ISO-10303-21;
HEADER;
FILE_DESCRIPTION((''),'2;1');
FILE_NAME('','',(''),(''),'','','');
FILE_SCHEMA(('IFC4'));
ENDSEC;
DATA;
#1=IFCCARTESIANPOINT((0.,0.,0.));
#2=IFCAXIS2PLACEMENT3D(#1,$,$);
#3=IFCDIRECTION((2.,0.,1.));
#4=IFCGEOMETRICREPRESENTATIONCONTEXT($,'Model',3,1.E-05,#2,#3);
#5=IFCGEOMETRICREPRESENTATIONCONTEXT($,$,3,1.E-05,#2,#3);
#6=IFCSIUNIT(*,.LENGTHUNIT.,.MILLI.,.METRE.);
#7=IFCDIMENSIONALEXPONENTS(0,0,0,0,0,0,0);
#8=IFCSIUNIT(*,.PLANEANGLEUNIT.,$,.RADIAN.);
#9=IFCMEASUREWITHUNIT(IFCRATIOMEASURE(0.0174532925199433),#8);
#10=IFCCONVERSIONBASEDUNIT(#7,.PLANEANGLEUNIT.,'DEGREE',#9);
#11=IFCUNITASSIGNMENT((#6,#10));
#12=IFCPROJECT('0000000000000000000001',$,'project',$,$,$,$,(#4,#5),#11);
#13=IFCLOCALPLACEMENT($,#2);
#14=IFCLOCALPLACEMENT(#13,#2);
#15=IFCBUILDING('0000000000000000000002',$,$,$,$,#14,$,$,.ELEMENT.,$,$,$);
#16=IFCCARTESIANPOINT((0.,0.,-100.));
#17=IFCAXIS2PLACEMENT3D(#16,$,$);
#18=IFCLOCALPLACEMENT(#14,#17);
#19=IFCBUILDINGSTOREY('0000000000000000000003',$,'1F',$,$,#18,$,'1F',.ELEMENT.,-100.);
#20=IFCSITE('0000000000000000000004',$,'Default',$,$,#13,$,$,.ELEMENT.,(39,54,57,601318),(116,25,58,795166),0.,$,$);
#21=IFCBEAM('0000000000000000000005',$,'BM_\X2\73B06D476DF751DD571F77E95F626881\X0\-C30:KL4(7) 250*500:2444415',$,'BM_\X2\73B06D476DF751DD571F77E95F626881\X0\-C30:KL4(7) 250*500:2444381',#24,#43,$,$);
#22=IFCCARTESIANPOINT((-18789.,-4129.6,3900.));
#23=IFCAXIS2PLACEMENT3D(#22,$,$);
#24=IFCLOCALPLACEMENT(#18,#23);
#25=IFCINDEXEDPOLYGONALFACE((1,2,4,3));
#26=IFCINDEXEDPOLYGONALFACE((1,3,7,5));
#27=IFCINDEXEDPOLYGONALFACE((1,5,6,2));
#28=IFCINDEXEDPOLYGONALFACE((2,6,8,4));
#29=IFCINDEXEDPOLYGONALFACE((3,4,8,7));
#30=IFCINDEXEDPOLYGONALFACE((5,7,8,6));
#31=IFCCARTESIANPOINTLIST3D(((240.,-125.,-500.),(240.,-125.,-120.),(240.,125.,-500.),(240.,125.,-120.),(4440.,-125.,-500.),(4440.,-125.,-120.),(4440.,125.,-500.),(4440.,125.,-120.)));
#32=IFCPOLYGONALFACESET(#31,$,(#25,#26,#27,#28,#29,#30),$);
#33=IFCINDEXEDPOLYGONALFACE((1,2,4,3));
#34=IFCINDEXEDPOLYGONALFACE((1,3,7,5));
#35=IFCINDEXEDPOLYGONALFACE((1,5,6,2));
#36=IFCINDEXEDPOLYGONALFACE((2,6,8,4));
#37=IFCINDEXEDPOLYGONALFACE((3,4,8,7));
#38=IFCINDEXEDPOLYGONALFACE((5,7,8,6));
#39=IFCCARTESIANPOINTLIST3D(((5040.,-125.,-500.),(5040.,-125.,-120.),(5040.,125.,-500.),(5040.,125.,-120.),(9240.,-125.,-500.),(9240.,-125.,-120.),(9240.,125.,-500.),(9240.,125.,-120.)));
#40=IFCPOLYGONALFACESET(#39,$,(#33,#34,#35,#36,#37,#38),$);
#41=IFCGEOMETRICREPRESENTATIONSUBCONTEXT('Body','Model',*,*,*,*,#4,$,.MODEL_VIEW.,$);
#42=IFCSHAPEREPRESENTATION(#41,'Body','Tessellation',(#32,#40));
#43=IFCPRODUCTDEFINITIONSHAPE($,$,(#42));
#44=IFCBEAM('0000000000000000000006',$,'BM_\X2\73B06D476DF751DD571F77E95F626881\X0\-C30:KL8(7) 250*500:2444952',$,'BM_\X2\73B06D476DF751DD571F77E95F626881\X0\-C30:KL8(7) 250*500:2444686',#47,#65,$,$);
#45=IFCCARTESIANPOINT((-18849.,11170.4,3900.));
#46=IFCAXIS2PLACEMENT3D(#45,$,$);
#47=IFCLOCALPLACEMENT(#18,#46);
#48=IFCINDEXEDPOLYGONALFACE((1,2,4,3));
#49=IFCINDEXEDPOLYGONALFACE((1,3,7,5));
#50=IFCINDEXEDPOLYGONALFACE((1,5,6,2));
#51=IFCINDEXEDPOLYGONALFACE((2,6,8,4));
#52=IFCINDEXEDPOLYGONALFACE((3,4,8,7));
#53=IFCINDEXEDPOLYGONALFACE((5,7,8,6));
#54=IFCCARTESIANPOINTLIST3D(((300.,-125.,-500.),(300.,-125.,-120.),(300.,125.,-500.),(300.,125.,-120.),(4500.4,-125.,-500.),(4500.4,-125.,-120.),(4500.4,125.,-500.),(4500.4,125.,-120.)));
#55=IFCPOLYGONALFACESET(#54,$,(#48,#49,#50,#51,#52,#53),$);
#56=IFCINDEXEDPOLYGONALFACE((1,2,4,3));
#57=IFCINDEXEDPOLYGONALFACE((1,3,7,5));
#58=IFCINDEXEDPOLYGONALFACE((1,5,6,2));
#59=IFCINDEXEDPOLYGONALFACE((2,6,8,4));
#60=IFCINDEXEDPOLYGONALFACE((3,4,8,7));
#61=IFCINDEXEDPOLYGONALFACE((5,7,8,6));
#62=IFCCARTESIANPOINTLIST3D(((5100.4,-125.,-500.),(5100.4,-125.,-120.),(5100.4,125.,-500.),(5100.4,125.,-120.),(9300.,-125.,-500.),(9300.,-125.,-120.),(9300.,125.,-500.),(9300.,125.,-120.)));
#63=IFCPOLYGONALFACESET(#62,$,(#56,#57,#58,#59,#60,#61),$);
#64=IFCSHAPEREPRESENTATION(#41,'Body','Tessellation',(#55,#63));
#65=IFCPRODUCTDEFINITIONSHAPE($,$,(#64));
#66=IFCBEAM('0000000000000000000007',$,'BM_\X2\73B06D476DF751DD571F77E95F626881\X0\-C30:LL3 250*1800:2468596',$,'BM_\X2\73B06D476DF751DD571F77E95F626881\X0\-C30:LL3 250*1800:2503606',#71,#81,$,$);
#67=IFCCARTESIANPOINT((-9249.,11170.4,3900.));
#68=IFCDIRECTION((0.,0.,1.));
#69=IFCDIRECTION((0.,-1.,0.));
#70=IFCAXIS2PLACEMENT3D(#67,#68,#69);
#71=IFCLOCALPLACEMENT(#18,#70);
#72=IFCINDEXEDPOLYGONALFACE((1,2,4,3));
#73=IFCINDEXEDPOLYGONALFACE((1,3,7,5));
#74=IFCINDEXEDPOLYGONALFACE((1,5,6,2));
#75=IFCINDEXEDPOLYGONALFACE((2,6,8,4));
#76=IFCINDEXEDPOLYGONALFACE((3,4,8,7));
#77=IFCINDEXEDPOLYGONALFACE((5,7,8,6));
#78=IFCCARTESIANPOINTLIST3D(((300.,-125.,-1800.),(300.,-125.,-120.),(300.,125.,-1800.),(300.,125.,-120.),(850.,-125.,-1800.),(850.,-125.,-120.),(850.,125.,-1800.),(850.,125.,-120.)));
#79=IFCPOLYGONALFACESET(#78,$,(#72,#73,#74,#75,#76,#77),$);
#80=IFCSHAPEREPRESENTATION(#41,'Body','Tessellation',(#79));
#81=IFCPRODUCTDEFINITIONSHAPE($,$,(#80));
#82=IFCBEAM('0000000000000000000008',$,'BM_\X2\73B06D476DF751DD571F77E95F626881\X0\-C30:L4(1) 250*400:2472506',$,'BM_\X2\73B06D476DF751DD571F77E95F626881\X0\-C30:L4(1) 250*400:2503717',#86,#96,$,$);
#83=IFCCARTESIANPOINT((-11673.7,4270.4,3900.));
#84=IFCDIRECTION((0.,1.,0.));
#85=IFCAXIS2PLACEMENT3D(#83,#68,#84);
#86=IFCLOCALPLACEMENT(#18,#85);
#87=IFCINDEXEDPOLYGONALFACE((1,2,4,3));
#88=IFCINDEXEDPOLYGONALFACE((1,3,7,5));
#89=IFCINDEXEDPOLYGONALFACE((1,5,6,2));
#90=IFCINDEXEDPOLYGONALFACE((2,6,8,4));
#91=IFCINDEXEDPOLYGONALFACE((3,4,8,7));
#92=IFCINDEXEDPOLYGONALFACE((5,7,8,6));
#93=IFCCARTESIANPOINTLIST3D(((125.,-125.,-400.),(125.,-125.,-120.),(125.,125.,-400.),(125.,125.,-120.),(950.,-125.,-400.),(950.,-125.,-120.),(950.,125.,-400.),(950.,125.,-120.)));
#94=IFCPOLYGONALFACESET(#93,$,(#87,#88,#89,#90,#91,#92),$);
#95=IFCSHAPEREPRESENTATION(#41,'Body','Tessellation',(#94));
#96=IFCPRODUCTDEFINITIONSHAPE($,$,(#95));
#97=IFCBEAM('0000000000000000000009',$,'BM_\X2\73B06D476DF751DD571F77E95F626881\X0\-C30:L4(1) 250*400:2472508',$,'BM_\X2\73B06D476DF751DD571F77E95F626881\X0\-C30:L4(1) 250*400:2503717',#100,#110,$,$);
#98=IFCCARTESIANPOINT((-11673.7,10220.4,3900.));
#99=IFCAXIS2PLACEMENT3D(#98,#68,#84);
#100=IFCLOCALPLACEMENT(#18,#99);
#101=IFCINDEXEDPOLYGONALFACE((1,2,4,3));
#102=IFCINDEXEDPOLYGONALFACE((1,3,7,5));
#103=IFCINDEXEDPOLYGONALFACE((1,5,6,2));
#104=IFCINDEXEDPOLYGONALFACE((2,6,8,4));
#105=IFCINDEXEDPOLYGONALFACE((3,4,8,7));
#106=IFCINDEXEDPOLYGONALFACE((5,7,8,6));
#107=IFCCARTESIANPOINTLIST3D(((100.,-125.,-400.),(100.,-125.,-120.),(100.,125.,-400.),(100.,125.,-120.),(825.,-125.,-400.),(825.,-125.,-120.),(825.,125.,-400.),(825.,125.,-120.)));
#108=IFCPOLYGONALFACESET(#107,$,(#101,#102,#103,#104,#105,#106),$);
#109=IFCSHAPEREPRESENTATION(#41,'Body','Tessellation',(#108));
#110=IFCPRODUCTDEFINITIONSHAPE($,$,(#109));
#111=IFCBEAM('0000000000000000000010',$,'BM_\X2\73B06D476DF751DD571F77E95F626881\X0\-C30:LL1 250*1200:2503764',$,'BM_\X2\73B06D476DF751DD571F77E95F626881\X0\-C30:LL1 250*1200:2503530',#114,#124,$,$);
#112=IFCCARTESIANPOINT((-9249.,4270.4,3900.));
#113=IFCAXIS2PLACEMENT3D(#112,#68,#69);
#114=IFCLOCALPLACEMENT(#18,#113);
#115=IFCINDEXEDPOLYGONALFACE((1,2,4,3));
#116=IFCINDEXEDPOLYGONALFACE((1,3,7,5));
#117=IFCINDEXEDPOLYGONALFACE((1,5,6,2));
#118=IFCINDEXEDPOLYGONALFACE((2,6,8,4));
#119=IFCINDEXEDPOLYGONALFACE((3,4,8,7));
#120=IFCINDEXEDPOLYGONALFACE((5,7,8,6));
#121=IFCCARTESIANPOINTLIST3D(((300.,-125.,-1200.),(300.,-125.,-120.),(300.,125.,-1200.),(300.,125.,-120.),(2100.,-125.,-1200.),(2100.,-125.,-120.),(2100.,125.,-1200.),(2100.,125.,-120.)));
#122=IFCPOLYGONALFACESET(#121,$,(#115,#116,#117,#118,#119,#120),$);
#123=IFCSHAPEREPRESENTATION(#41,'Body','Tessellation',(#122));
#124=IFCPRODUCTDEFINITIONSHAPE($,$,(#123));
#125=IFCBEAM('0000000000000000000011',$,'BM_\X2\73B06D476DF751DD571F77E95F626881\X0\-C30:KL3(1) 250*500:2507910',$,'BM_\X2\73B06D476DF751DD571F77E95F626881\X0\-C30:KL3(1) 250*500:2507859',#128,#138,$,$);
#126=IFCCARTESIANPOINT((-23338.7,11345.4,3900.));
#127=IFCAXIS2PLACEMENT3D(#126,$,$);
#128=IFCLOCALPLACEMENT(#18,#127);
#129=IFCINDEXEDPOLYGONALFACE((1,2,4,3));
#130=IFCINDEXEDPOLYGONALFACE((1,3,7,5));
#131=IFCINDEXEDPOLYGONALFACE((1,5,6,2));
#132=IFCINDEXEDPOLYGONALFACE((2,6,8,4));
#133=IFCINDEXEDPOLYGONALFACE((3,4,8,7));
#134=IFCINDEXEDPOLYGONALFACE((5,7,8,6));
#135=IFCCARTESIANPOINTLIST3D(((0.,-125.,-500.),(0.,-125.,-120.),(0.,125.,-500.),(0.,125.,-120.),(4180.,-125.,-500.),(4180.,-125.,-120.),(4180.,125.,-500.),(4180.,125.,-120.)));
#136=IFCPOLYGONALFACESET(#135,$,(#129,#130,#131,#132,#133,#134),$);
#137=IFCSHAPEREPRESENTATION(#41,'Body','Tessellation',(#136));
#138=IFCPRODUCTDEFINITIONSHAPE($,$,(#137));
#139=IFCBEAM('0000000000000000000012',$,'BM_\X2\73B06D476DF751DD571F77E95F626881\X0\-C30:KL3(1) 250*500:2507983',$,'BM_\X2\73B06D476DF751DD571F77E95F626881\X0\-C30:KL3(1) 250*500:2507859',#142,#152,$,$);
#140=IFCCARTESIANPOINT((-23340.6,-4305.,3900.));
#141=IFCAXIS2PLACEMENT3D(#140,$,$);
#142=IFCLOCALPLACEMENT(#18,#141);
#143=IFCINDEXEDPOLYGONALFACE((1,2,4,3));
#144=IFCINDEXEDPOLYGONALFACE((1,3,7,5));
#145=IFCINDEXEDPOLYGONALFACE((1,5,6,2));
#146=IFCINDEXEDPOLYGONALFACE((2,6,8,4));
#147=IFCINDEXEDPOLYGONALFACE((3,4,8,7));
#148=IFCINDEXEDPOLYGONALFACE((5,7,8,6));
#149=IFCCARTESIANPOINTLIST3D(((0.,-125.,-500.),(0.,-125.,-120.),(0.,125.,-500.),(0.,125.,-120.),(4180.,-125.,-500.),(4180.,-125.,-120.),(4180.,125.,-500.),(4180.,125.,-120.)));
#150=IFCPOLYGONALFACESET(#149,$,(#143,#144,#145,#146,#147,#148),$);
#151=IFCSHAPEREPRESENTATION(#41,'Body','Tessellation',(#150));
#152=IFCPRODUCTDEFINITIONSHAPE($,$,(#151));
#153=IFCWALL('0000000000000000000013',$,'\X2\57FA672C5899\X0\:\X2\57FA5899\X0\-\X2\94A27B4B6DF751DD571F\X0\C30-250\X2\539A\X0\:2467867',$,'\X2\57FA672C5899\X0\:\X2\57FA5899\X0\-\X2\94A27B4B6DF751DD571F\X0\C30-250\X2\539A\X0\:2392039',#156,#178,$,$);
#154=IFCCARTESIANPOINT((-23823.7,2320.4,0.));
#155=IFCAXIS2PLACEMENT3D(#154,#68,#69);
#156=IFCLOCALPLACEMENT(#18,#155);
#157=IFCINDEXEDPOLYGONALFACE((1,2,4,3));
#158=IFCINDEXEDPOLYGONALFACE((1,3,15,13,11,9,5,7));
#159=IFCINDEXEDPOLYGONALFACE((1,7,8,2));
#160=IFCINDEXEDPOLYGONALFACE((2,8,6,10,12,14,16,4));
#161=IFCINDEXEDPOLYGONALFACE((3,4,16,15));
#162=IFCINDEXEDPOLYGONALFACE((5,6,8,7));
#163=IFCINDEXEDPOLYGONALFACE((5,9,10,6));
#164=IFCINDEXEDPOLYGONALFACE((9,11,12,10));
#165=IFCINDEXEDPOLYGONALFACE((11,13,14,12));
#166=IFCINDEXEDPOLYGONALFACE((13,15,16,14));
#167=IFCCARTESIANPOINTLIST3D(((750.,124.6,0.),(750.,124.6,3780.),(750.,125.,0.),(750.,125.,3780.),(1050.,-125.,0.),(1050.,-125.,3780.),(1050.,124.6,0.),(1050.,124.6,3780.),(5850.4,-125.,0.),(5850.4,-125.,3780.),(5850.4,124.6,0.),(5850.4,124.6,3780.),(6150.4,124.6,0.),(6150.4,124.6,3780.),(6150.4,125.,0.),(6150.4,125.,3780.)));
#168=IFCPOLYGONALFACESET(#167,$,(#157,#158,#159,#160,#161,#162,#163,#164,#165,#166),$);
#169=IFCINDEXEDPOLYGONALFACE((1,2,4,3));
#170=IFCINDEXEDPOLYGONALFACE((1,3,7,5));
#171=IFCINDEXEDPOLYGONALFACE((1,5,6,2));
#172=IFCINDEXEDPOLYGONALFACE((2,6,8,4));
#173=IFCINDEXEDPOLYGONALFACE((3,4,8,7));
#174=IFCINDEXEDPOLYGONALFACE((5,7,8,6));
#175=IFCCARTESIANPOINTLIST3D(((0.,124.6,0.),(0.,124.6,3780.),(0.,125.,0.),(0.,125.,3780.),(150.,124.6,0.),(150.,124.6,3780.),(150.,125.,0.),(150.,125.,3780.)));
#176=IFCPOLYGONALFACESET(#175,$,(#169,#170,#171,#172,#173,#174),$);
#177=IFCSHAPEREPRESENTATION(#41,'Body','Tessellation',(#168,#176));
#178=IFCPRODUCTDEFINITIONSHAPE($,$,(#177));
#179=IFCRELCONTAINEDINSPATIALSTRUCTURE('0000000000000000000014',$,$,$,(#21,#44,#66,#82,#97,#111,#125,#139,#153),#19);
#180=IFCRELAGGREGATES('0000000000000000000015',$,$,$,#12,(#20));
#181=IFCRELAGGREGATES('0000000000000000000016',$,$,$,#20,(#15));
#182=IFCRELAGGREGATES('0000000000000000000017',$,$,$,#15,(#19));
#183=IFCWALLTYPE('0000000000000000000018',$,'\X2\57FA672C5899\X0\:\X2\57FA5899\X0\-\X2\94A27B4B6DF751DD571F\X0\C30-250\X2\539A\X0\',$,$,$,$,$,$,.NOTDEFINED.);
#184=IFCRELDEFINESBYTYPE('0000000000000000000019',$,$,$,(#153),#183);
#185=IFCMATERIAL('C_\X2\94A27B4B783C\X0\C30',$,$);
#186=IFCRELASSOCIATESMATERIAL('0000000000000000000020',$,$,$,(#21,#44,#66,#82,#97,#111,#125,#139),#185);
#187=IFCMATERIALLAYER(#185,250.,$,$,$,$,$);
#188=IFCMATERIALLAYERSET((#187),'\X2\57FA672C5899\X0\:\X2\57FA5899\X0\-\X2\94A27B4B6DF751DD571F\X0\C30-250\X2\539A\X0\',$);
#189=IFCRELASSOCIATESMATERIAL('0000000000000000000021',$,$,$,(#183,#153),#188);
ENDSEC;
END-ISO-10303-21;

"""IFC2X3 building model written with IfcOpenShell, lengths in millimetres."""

from ifc_helpers import new_model, entity, si_unit, converted_unit, direction, frame, frame_2d, origin, origin_2d_with_axis, place, context, subcontext, project, spatial, polyline, rectangle, outline, extrude, material, layer, layer_set, type_object, element, save


model = new_model("IFC2X3")

# Units and contexts
model_context = context("Model", 3, precision=1e-05, world=origin(), true_north=direction((2.0, 0.0, 1.0)))
context_of_model = context(None, 3, precision=1e-05, world=origin(), true_north=direction((2.0, 0.0, 1.0)))
body_context = subcontext(model_context, "Body", "Model", "MODEL_VIEW")
ifc_project = project(units=[si_unit("LENGTHUNIT", "METRE", prefix="MILLI"), converted_unit("PLANEANGLEUNIT", "DEGREE", entity("IfcRatioMeasure", 0.0174532925199433), si_unit("PLANEANGLEUNIT", "RADIAN"), dimensions=[0, 0, 0, 0, 0, 0, 0])], contexts=[model_context, context_of_model])

# Site, building, storey
site_placement = place(None, origin())
site = spatial("IfcSite", under=ifc_project, at=site_placement, Name="Default", CompositionType="ELEMENT", RefLatitude=(39, 54, 57, 601318), RefLongitude=(116, 25, 58, 795166), RefElevation=0.0)
building_placement = place(site_placement, origin())
building = spatial("IfcBuilding", under=site, at=building_placement, CompositionType="ELEMENT")
storey_placement = place(building_placement, frame((0.0, 0.0, -100.0)))
storey = spatial("IfcBuildingStorey", under=building, at=storey_placement, Name="1F", LongName="1F", CompositionType="ELEMENT", Elevation=-100.0)

# Beams
ifc_material = material(Name="C_钢筋砼C30")
beam_1_placement = place(storey_placement, frame((-18789.0, -4129.6, 3900.0)))
element("IfcBeam", 1, at=beam_1_placement, inside=storey, material=ifc_material, Name="BM_现浇混凝土矩形梁-C30:KL4(7) 250*500:2444415", ObjectType="BM_现浇混凝土矩形梁-C30:KL4(7) 250*500:2444381", context=body_context, shape_type="SweptSolid", body=[
    extrude(rectangle(XDim=380.0, YDim=250.0, at=origin_2d_with_axis()), frame((240.0, 0.0, -310.0), z_axis=(1.0, 0.0, 0.0), x_axis=(0.0, 0.0, 1.0)), (0.0, 0.0, 1.0), 4200.0),
    extrude(rectangle(XDim=380.0, YDim=250.0, at=frame_2d((0.0, 0.0), x_axis=(1.0, 0.0))), frame((5040.0, 0.0, -310.0), z_axis=(1.0, 0.0, 0.0), x_axis=(0.0, 0.0, 1.0)), (0.0, 0.0, 1.0), 4200.0),
])
beam_2_placement = place(storey_placement, frame((-18849.0, 11170.4, 3900.0)))
element("IfcBeam", 2, at=beam_2_placement, inside=storey, material=ifc_material, Name="BM_现浇混凝土矩形梁-C30:KL8(7) 250*500:2444952", ObjectType="BM_现浇混凝土矩形梁-C30:KL8(7) 250*500:2444686", context=body_context, shape_type="SweptSolid", body=[
    extrude(rectangle(XDim=380.0, YDim=250.0, at=origin_2d_with_axis()), frame((300.0, 0.0, -310.0), z_axis=(1.0, 0.0, 0.0), x_axis=(0.0, 0.0, 1.0)), (0.0, 0.0, 1.0), 4200.4),
    extrude(rectangle(XDim=380.0, YDim=250.0, at=origin_2d_with_axis()), frame((5100.4, 0.0, -310.0), z_axis=(1.0, 0.0, 0.0), x_axis=(0.0, 0.0, 1.0)), (0.0, 0.0, 1.0), 4199.6),
])
beam_3_placement = place(storey_placement, frame((-9249.0, 11170.4, 3900.0), z_axis=(0.0, 0.0, 1.0), x_axis=(0.0, -1.0, 0.0)))
element("IfcBeam", 3, at=beam_3_placement, inside=storey, material=ifc_material, Name="BM_现浇混凝土矩形梁-C30:LL3 250*1800:2468596", ObjectType="BM_现浇混凝土矩形梁-C30:LL3 250*1800:2503606", context=body_context, shape_type="SweptSolid", body=[
    extrude(rectangle(XDim=1680.0, YDim=250.0, at=frame_2d((0.0, 0.0), x_axis=(1.0, 0.0))), frame((300.0, 0.0, -960.0), z_axis=(1.0, 0.0, 0.0), x_axis=(0.0, 0.0, -1.0)), (0.0, 0.0, 1.0), 550.0),
])
beam_4_placement = place(storey_placement, frame((-11673.7, 4270.4, 3900.0), z_axis=(0.0, 0.0, 1.0), x_axis=(0.0, 1.0, 0.0)))
element("IfcBeam", 4, at=beam_4_placement, inside=storey, material=ifc_material, Name="BM_现浇混凝土矩形梁-C30:L4(1) 250*400:2472506", ObjectType="BM_现浇混凝土矩形梁-C30:L4(1) 250*400:2503717", context=body_context, shape_type="SweptSolid", body=[
    extrude(rectangle(XDim=280.0, YDim=250.0, at=frame_2d((0.0, 0.0), x_axis=(1.0, 0.0))), frame((125.0, 0.0, -260.0), z_axis=(1.0, 0.0, 0.0), x_axis=(0.0, 0.0, -1.0)), (0.0, 0.0, 1.0), 825.0),
])
beam_5_placement = place(storey_placement, frame((-11673.7, 10220.4, 3900.0), z_axis=(0.0, 0.0, 1.0), x_axis=(0.0, 1.0, 0.0)))
element("IfcBeam", 5, at=beam_5_placement, inside=storey, material=ifc_material, Name="BM_现浇混凝土矩形梁-C30:L4(1) 250*400:2472508", ObjectType="BM_现浇混凝土矩形梁-C30:L4(1) 250*400:2503717", context=body_context, shape_type="SweptSolid", body=[
    extrude(rectangle(XDim=280.0, YDim=250.0, at=origin_2d_with_axis()), frame((100.0, 0.0, -260.0), z_axis=(1.0, 0.0, 0.0), x_axis=(0.0, 0.0, -1.0)), (0.0, 0.0, 1.0), 725.0),
])
beam_6_placement = place(storey_placement, frame((-9249.0, 4270.4, 3900.0), z_axis=(0.0, 0.0, 1.0), x_axis=(0.0, -1.0, 0.0)))
element("IfcBeam", 6, at=beam_6_placement, inside=storey, material=ifc_material, Name="BM_现浇混凝土矩形梁-C30:LL1 250*1200:2503764", ObjectType="BM_现浇混凝土矩形梁-C30:LL1 250*1200:2503530", context=body_context, shape_type="SweptSolid", body=[
    extrude(rectangle(XDim=1080.0, YDim=250.0, at=frame_2d((0.0, 0.0), x_axis=(1.0, 0.0))), frame((300.0, 0.0, -660.0), z_axis=(1.0, 0.0, 0.0), x_axis=(0.0, 0.0, -1.0)), (0.0, 0.0, 1.0), 1800.0),
])
for number, where, name in (
    (7, (-23338.7, 11345.4, 3900.0), "BM_现浇混凝土矩形梁-C30:KL3(1) 250*500:2507910"),
    (8, (-23340.6, -4305.0, 3900.0), "BM_现浇混凝土矩形梁-C30:KL3(1) 250*500:2507983"),
):
    element("IfcBeam", number, at=place(storey_placement, frame(where)), inside=storey, material=ifc_material, Name=name, ObjectType="BM_现浇混凝土矩形梁-C30:KL3(1) 250*500:2507859", context=body_context, shape_type="SweptSolid", body=[
        extrude(rectangle(XDim=380.0, YDim=250.0, at=frame_2d((0.0, 0.0), x_axis=(1.0, 0.0))), frame((0.0, 0.0, -310.0), z_axis=(1.0, 0.0, 0.0), x_axis=(0.0, 0.0, -1.0)), (0.0, 0.0, 1.0), 4180.0),
    ])

# Wall
ifc_layer_1 = layer(ifc_material, 250.0)
ifc_layer_set_1 = layer_set([ifc_layer_1], Name="基本墙:基墙-钢筋混凝土C30-250厚")
wall_type_1 = type_object("IfcWallType", Name="基本墙:基墙-钢筋混凝土C30-250厚", PredefinedType="NOTDEFINED", material=ifc_layer_set_1)
wall_1_placement = place(storey_placement, frame((-23823.7, 2320.4, 0.0), z_axis=(0.0, 0.0, 1.0), x_axis=(0.0, -1.0, 0.0)))
element("IfcWall", 9, at=wall_1_placement, inside=storey, type_object=wall_type_1, material=ifc_layer_set_1, Name="基本墙:基墙-钢筋混凝土C30-250厚:2467867", ObjectType="基本墙:基墙-钢筋混凝土C30-250厚:2392039", context=body_context, shape_type="SweptSolid", body=[
    extrude(outline(polyline([(-2700.2, -62.7), (2700.2, -62.7), (2700.2, -62.3), (2400.2, -62.3), (2400.2, 187.3), (-2400.2, 187.3), (-2400.2, -62.3), (-2700.2, -62.3), (-2700.2, -62.7)])), frame((3450.2, 62.3, 0.0), z_axis=(0.0, 0.0, 1.0), x_axis=(-1.0, 0.0, 0.0)), (0.0, 0.0, 1.0), 3780.0),
    extrude(rectangle(XDim=150.0, YDim=0.4, at=frame_2d((0.0, 0.0), x_axis=(1.0, 0.0))), frame((75.0, 124.8, 0.0)), (0.0, 0.0, 1.0), 3780.0),
])

save(model, "model.ifc")
